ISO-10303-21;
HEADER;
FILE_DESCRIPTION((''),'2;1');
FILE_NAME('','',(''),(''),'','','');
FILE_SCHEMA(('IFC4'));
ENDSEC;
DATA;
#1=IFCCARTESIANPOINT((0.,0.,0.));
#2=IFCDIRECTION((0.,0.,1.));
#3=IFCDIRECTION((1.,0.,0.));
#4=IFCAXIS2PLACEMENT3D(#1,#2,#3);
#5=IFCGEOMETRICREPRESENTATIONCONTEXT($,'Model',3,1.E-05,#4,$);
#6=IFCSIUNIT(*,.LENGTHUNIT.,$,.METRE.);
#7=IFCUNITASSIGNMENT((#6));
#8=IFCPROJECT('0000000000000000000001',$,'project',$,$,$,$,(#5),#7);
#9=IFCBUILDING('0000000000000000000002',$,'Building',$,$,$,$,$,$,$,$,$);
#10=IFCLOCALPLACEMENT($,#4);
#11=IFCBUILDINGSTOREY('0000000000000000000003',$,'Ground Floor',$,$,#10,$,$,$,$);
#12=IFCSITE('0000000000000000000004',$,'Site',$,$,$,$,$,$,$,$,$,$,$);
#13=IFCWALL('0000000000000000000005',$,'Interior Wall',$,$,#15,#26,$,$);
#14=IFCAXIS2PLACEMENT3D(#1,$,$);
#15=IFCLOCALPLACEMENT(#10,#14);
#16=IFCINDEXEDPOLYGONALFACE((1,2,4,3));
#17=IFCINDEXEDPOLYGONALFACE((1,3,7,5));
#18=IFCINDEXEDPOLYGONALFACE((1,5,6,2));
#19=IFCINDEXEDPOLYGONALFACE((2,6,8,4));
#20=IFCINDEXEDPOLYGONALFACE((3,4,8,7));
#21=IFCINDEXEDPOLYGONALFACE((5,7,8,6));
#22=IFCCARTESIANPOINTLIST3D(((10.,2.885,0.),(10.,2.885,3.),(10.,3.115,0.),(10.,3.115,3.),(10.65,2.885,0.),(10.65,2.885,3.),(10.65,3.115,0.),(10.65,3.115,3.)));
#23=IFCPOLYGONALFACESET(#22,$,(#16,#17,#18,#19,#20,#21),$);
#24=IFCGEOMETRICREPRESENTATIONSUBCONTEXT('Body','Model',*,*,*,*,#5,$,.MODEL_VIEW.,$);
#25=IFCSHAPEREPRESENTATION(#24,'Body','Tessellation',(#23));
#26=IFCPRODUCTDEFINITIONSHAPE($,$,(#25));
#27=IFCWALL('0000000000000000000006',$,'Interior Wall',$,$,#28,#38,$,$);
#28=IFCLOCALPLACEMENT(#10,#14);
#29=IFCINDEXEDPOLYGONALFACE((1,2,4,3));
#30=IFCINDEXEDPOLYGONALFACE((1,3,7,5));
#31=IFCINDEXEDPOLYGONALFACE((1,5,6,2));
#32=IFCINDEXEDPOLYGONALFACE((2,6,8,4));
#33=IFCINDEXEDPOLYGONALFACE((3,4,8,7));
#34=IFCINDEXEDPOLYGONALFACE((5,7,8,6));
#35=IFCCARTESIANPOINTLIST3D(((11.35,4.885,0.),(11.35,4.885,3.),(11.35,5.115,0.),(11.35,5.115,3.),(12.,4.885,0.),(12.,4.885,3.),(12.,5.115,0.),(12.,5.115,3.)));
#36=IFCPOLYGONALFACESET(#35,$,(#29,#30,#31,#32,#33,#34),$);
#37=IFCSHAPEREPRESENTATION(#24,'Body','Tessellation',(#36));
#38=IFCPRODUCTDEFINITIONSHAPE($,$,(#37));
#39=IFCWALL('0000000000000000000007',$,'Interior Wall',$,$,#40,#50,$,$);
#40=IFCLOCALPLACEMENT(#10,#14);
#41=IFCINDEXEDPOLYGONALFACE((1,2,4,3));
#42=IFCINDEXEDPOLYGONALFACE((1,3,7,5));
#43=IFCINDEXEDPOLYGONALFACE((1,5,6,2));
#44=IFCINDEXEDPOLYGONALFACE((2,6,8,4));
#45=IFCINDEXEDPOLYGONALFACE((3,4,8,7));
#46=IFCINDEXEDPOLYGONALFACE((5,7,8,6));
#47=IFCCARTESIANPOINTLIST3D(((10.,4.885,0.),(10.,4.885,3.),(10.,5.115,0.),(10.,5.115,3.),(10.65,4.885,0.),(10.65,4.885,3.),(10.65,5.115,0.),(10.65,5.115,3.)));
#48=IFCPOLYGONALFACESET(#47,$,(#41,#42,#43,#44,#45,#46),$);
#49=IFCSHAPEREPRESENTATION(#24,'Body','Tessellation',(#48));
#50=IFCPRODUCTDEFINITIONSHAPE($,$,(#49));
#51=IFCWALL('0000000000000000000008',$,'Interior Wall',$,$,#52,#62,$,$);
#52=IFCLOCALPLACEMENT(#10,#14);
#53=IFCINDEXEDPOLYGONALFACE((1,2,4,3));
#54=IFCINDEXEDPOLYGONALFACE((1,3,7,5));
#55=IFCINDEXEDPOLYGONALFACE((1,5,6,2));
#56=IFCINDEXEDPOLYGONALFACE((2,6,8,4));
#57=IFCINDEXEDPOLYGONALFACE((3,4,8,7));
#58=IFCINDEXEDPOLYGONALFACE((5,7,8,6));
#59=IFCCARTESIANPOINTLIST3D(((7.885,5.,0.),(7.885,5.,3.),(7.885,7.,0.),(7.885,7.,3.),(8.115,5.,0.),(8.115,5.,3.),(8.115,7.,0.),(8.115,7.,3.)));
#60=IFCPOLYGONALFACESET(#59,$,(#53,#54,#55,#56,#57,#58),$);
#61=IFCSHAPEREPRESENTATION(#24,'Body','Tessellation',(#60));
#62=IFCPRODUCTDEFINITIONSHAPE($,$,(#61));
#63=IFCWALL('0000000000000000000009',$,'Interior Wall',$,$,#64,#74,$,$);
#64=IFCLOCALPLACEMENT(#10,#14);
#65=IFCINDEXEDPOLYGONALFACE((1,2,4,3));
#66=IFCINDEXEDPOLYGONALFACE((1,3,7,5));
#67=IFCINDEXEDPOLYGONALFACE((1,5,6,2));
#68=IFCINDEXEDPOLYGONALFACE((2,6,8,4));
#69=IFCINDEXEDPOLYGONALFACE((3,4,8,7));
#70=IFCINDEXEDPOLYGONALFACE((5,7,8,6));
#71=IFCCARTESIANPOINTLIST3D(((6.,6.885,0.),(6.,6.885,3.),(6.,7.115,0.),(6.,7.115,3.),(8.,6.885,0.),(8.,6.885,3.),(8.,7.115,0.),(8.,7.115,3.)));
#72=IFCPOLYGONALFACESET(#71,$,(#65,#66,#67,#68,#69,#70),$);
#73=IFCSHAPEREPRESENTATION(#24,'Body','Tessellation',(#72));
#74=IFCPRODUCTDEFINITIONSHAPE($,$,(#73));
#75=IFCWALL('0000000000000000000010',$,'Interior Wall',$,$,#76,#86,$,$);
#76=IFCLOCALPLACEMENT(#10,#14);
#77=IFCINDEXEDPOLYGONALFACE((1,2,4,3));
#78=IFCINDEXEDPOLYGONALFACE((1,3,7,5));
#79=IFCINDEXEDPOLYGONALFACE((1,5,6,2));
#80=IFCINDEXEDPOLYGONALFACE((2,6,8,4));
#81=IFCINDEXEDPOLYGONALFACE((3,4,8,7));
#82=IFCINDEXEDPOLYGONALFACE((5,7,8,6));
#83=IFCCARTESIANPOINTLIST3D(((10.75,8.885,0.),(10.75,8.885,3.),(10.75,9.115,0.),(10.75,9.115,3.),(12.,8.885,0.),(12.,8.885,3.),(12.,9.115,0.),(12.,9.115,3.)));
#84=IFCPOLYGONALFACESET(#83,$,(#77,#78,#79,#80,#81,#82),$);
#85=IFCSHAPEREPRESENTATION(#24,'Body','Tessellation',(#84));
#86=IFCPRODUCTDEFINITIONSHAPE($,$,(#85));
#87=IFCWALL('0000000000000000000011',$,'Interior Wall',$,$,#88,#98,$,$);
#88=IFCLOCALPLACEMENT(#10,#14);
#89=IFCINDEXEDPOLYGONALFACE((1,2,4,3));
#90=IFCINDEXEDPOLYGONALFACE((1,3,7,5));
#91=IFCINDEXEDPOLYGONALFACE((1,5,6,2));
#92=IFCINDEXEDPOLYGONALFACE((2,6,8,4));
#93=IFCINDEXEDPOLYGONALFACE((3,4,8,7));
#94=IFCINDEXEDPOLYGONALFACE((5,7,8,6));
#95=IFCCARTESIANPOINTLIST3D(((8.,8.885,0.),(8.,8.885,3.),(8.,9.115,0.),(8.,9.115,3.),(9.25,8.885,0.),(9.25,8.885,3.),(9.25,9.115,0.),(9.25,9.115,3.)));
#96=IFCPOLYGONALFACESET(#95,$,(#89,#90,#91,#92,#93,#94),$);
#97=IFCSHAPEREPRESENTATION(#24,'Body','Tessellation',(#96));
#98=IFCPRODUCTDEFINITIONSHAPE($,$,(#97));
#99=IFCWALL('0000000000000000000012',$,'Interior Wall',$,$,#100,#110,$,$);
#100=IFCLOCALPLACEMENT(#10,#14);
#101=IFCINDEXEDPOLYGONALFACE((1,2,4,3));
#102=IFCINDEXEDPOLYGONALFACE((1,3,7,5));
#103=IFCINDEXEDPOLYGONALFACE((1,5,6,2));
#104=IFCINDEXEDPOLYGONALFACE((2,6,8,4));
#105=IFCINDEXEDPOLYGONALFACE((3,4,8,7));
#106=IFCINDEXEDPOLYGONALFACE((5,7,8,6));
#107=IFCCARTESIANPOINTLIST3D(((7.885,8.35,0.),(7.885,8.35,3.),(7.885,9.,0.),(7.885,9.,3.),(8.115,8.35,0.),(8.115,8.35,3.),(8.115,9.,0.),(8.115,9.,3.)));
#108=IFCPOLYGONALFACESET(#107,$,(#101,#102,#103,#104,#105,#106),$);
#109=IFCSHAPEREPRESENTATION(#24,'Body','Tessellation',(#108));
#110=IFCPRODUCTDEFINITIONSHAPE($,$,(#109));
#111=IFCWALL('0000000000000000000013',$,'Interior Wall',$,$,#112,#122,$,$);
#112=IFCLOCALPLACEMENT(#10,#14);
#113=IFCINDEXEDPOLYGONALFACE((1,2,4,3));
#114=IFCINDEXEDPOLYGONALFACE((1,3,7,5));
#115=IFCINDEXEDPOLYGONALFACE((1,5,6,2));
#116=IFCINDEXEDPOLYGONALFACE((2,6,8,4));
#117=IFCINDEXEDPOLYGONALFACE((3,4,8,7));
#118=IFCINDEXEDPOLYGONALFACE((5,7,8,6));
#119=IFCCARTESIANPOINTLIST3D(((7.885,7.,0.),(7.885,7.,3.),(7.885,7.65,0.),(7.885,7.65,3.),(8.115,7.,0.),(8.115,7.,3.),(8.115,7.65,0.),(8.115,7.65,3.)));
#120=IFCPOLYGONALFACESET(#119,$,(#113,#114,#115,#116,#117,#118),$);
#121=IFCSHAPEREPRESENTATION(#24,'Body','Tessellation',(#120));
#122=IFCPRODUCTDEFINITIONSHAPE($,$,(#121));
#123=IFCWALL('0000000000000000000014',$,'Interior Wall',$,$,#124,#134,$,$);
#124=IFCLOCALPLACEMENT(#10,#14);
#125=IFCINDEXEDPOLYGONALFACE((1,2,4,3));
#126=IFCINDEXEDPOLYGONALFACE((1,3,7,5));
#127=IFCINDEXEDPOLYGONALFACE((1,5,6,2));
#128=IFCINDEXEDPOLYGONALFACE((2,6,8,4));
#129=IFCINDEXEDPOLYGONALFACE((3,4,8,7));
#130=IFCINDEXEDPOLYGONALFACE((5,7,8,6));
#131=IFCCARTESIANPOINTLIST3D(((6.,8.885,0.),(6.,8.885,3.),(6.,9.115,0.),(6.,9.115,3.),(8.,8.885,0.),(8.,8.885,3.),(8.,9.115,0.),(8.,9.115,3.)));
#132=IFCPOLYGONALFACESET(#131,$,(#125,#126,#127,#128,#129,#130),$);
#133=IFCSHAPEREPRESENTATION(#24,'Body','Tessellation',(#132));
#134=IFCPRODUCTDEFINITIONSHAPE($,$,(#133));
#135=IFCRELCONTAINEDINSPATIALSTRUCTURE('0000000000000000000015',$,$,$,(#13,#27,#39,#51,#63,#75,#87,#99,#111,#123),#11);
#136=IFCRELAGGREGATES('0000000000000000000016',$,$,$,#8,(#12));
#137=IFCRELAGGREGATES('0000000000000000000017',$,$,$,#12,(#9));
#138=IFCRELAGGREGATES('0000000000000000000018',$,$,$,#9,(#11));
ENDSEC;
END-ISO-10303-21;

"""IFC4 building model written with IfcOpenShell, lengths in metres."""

from ifc_helpers import new_model, si_unit, frame, origin_with_axes, place, context, subcontext, project, spatial, indexed_curve, outline, extrude, element, save


model = new_model("IFC4")

# Units and contexts
model_context = context("Model", 3, precision=1e-05, world=origin_with_axes())
body_context = subcontext(model_context, "Body", "Model", "MODEL_VIEW")
ifc_project = project(units=[si_unit("LENGTHUNIT", "METRE")], contexts=[model_context])

# Site, building, storey
site = spatial("IfcSite", under=ifc_project, Name="Site")
building = spatial("IfcBuilding", under=site, Name="Building")
storey_placement = place(None, origin_with_axes())
storey = spatial("IfcBuildingStorey", under=building, at=storey_placement, Name="Ground Floor")

# Walls
for number, where, z_axis, x_axis, name in (
    (1, (10.65, 3.0, 0.0), (0.0, 0.0, 1.0), (-1.0, 0.0, 0.0), "Interior Wall"),
    (2, (12.0, 5.0, 0.0), (0.0, 0.0, 1.0), (-1.0, 0.0, 0.0), "Interior Wall"),
    (3, (10.65, 5.0, 0.0), (0.0, 0.0, 1.0), (-1.0, 0.0, 0.0), "Interior Wall"),
):
    element("IfcWall", number, at=place(storey_placement, frame(where, z_axis=z_axis, x_axis=x_axis)), inside=storey, Name=name, context=body_context, shape_type="SweptSolid", body=[
        extrude(outline(indexed_curve([(0.0, 0.0), (0.0, 0.23), (0.65, 0.23), (0.65, 0.0), (0.0, 0.0)], self_intersect=False)), frame((0.0, -0.115, 0.0), z_axis=(0.0, 0.0, 1.0), x_axis=(1.0, 0.0, 0.0)), (0.0, 0.0, 1.0), 3.0),
    ])
for number, where, z_axis, x_axis, name in (
    (4, (8.0, 5.0, 0.0), (0.0, 0.0, 1.0), (0.0, 1.0, 0.0), "Interior Wall"),
    (5, (8.0, 7.0, 0.0), (0.0, 0.0, 1.0), (-1.0, 0.0, 0.0), "Interior Wall"),
):
    element("IfcWall", number, at=place(storey_placement, frame(where, z_axis=z_axis, x_axis=x_axis)), inside=storey, Name=name, context=body_context, shape_type="SweptSolid", body=[
        extrude(outline(indexed_curve([(0.0, 0.0), (0.0, 0.23), (2.0, 0.23), (2.0, 0.0), (0.0, 0.0)], self_intersect=False)), frame((0.0, -0.115, 0.0), z_axis=(0.0, 0.0, 1.0), x_axis=(1.0, 0.0, 0.0)), (0.0, 0.0, 1.0), 3.0),
    ])
for number, where, z_axis, x_axis, name in (
    (6, (12.0, 9.0, 0.0), (0.0, 0.0, 1.0), (-1.0, 0.0, 0.0), "Interior Wall"),
    (7, (9.25, 9.0, 0.0), (0.0, 0.0, 1.0), (-1.0, 0.0, 0.0), "Interior Wall"),
):
    element("IfcWall", number, at=place(storey_placement, frame(where, z_axis=z_axis, x_axis=x_axis)), inside=storey, Name=name, context=body_context, shape_type="SweptSolid", body=[
        extrude(outline(indexed_curve([(0.0, 0.0), (0.0, 0.23), (1.25, 0.23), (1.25, 0.0), (0.0, 0.0)], self_intersect=False)), frame((0.0, -0.115, 0.0), z_axis=(0.0, 0.0, 1.0), x_axis=(1.0, 0.0, 0.0)), (0.0, 0.0, 1.0), 3.0),
    ])
for number, where, z_axis, x_axis, name in (
    (8, (8.0, 9.0, 0.0), (0.0, 0.0, 1.0), (0.0, -1.0, 0.0), "Interior Wall"),
    (9, (8.0, 7.65, 0.0), (0.0, 0.0, 1.0), (0.0, -1.0, 0.0), "Interior Wall"),
):
    element("IfcWall", number, at=place(storey_placement, frame(where, z_axis=z_axis, x_axis=x_axis)), inside=storey, Name=name, context=body_context, shape_type="SweptSolid", body=[
        extrude(outline(indexed_curve([(0.0, 0.0), (0.0, 0.23), (0.65, 0.23), (0.65, 0.0), (0.0, 0.0)], self_intersect=False)), frame((0.0, -0.115, 0.0), z_axis=(0.0, 0.0, 1.0), x_axis=(1.0, 0.0, 0.0)), (0.0, 0.0, 1.0), 3.0),
    ])
wall_1_placement = place(storey_placement, frame((8.0, 9.0, 0.0), z_axis=(0.0, 0.0, 1.0), x_axis=(-1.0, 0.0, 0.0)))
element("IfcWall", 10, at=wall_1_placement, inside=storey, Name="Interior Wall", context=body_context, shape_type="SweptSolid", body=[
    extrude(outline(indexed_curve([(0.0, 0.0), (0.0, 0.23), (2.0, 0.23), (2.0, 0.0), (0.0, 0.0)], self_intersect=False)), frame((0.0, -0.115, 0.0), z_axis=(0.0, 0.0, 1.0), x_axis=(1.0, 0.0, 0.0)), (0.0, 0.0, 1.0), 3.0),
])

save(model, "model.ifc")
